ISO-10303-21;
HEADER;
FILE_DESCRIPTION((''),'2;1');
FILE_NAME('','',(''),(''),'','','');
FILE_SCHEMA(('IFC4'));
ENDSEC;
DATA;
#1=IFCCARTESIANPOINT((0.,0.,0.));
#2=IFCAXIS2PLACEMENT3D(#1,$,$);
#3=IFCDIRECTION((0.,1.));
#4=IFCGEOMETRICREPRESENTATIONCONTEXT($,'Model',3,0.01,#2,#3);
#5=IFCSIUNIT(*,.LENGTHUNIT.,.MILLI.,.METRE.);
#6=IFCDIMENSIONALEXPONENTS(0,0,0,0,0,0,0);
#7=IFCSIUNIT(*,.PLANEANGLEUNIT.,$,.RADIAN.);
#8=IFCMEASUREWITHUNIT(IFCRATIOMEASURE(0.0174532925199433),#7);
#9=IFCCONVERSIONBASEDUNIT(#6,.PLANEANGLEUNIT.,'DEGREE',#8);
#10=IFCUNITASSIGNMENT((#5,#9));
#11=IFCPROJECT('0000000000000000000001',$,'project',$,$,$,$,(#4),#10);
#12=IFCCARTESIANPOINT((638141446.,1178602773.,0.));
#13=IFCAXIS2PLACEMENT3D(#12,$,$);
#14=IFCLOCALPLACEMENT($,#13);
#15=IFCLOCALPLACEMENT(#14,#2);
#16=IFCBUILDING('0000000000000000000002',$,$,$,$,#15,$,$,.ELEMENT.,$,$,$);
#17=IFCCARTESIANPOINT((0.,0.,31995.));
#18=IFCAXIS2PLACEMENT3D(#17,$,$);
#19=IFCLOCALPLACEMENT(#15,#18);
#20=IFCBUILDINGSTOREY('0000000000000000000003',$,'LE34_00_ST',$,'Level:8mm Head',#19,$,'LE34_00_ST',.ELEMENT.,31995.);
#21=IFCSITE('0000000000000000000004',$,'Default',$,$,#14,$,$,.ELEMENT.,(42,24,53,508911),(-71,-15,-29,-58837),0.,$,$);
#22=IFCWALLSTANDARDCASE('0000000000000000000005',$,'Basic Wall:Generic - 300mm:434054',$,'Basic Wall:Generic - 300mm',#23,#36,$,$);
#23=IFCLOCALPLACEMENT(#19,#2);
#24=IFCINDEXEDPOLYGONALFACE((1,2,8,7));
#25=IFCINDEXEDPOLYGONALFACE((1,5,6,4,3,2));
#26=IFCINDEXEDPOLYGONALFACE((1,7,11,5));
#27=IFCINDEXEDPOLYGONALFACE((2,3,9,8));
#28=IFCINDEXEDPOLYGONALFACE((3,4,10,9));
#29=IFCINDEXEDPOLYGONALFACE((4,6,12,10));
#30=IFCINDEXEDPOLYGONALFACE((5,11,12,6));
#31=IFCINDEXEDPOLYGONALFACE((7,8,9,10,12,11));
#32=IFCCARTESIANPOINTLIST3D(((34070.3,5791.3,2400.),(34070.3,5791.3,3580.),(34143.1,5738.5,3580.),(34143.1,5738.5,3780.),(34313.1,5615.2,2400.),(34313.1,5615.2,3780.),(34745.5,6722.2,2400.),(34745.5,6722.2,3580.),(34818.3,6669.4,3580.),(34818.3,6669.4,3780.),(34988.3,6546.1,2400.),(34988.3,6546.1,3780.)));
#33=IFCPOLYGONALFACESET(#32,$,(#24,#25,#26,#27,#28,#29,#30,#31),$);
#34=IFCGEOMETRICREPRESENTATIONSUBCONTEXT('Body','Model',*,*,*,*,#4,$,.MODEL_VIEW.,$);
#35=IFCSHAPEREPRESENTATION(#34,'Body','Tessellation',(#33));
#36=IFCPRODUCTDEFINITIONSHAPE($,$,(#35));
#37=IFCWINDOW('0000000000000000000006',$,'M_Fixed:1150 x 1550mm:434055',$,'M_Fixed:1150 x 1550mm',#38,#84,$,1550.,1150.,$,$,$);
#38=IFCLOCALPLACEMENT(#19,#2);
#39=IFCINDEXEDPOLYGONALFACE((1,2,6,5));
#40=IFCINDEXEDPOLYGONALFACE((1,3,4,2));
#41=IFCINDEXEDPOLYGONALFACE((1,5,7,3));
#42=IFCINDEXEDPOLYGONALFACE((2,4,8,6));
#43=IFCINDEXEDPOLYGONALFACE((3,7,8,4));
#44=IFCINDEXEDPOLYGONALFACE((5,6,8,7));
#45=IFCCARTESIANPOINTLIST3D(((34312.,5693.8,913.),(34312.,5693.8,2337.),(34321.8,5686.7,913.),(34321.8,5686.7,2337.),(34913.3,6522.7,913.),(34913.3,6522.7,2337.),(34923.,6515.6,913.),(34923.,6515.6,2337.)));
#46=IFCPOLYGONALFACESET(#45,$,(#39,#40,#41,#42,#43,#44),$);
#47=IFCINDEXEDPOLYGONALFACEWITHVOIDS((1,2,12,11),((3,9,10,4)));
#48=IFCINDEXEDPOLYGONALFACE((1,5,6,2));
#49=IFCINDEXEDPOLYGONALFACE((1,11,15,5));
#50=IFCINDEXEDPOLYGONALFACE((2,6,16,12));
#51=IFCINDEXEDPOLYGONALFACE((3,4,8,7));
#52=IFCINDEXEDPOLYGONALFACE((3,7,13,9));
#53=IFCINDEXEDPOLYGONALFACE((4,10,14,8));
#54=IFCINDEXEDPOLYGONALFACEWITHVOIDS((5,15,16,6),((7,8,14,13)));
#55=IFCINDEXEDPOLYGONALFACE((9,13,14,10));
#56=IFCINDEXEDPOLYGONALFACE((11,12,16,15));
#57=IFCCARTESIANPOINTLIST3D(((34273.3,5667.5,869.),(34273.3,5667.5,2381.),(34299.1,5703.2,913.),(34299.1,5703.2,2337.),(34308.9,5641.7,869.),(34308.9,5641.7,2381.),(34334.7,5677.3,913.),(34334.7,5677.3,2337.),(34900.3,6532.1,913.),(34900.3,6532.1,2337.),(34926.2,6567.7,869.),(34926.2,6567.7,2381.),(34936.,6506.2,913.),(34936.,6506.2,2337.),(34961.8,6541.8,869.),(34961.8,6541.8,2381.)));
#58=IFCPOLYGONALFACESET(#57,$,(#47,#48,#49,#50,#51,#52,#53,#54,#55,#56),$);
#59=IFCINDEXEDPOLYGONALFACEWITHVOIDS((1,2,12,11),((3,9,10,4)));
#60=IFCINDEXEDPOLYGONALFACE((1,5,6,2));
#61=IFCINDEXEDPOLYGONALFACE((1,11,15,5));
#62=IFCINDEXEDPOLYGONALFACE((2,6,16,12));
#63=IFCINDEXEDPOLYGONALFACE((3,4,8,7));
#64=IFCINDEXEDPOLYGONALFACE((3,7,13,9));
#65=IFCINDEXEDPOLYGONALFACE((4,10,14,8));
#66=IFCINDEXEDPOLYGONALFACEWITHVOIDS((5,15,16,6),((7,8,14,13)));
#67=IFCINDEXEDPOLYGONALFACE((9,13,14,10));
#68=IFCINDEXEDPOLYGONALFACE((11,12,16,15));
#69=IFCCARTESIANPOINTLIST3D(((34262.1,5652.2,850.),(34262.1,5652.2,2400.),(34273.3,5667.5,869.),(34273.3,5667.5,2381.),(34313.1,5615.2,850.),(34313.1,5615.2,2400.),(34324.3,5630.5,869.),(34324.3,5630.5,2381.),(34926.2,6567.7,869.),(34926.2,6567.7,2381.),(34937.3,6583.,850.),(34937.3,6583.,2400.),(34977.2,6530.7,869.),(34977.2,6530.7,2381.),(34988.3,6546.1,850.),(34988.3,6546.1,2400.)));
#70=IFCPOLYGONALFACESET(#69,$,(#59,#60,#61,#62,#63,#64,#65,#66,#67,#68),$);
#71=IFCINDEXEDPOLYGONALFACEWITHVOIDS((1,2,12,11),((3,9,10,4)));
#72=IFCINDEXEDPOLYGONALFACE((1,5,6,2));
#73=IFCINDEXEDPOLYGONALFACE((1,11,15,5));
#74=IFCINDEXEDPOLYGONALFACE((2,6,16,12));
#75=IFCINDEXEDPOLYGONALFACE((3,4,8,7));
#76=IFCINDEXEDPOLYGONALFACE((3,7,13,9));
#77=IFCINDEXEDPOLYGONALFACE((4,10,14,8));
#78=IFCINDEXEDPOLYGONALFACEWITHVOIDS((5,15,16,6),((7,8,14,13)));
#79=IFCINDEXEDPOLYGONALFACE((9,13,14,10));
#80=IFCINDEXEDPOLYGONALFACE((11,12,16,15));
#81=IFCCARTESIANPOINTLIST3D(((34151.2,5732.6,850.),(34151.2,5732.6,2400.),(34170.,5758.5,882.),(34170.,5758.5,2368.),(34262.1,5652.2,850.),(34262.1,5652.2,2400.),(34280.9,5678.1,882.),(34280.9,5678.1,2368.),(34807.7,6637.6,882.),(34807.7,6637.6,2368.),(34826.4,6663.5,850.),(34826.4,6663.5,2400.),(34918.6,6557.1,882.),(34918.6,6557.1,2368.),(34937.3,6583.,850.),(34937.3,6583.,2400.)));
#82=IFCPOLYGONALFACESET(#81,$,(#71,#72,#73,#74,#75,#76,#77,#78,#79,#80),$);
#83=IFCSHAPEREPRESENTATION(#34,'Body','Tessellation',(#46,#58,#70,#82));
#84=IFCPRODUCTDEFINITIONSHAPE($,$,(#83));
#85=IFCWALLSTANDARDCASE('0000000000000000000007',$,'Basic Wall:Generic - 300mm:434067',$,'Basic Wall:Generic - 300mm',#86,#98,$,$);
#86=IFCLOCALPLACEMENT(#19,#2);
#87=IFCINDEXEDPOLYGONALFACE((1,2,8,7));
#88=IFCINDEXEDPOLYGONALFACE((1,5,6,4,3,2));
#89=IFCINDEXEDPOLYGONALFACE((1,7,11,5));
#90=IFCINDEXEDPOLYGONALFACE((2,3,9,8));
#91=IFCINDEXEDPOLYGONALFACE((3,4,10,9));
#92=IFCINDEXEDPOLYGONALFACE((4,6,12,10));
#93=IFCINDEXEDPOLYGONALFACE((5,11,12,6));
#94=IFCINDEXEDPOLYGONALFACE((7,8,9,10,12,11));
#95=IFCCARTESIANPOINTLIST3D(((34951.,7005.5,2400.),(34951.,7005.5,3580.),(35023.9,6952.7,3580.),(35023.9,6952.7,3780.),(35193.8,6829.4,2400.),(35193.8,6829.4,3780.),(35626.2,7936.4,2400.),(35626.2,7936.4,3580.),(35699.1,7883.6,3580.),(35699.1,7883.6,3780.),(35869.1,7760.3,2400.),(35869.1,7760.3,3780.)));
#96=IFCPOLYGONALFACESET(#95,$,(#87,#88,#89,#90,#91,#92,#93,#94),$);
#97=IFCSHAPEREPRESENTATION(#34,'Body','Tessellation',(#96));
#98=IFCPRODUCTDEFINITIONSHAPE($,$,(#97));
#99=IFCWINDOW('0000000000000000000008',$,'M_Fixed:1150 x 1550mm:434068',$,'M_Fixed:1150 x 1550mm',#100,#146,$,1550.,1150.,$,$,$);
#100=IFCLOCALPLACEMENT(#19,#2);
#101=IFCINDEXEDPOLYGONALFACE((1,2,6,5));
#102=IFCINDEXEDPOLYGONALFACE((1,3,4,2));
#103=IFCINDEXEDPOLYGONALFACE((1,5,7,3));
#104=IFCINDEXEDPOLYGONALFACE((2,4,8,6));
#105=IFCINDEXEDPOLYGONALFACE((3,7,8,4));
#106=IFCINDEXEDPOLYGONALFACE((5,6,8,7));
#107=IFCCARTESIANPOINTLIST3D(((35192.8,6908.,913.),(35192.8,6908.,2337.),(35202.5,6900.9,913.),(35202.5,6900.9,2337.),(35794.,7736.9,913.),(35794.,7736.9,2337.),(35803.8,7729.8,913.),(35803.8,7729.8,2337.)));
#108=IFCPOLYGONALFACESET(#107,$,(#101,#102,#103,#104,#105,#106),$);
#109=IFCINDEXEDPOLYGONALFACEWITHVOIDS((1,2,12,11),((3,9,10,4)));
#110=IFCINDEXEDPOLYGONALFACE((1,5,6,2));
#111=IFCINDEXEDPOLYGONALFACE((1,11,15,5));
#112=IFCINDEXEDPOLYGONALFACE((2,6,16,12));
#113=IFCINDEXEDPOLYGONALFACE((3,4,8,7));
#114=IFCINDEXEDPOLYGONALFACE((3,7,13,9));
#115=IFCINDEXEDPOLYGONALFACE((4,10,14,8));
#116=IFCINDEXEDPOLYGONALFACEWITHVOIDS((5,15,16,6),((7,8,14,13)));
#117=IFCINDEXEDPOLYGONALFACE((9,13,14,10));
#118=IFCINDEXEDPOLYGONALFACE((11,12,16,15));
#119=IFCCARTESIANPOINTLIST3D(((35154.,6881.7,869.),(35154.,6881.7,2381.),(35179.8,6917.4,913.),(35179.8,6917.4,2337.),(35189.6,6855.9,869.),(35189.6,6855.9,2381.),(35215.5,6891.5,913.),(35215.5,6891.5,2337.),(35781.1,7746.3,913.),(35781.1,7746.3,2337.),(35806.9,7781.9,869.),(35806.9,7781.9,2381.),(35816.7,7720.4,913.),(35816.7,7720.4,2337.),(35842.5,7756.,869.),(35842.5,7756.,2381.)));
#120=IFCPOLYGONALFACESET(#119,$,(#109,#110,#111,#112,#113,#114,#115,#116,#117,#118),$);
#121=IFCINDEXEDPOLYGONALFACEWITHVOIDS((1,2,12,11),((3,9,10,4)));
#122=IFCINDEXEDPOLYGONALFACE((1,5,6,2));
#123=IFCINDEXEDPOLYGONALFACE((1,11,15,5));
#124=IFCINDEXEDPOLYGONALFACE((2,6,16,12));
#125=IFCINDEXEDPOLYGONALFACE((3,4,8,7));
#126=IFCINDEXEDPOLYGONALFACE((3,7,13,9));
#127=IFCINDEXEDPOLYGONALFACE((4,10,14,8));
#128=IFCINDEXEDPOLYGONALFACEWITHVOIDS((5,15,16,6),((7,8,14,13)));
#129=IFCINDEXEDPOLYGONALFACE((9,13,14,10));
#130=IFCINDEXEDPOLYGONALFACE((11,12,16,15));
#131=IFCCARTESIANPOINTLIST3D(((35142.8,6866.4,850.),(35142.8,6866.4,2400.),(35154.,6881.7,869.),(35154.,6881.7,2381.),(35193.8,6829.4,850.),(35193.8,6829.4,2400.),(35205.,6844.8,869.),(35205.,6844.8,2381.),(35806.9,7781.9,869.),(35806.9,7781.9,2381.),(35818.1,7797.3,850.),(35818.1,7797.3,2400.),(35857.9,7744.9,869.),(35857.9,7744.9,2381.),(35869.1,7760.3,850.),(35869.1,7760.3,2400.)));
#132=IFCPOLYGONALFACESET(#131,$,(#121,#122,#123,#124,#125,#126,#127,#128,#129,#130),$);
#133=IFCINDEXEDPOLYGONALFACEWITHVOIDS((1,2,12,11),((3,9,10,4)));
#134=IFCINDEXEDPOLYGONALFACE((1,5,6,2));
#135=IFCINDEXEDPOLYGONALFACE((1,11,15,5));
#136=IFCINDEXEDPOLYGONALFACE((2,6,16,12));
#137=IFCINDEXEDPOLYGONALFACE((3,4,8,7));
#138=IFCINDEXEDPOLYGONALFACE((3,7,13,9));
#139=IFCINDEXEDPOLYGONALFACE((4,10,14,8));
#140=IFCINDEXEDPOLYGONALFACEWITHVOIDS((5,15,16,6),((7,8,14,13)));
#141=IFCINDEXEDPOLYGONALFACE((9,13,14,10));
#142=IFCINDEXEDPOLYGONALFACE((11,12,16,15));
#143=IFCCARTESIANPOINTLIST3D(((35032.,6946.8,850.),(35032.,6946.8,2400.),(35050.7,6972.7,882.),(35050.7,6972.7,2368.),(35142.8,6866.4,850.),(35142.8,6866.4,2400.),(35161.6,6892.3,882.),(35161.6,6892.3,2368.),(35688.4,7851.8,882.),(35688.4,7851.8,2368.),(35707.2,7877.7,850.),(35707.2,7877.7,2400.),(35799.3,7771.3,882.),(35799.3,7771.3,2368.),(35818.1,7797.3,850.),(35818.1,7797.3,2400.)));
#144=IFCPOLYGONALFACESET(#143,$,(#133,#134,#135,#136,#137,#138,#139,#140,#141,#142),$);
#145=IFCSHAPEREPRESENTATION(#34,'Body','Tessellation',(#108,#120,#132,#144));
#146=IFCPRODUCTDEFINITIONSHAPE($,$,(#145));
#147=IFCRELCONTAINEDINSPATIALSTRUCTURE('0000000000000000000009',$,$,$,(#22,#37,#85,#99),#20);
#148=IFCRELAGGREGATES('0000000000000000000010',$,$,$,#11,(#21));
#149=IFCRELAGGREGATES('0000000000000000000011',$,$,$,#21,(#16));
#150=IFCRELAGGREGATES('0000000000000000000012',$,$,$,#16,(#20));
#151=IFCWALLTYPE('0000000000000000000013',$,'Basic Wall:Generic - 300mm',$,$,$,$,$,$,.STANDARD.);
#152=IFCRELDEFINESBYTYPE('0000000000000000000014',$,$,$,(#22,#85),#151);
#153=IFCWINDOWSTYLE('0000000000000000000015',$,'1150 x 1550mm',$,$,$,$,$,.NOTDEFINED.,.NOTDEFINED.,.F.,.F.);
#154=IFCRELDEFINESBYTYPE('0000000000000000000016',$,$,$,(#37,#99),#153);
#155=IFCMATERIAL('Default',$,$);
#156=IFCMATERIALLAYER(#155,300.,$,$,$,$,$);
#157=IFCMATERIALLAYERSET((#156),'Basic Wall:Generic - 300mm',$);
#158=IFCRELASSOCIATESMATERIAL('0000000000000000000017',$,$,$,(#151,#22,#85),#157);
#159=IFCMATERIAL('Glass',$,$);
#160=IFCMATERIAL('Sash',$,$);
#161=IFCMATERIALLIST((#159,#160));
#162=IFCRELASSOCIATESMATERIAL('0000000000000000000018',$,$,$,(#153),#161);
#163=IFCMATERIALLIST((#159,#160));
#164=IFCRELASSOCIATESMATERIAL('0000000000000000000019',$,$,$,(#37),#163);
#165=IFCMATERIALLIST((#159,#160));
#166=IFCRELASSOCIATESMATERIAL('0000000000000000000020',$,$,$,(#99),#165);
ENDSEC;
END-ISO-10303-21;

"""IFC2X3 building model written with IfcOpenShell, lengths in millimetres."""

from ifc_helpers import new_model, entity, si_unit, converted_unit, direction, frame, frame_2d, origin, place, context, subcontext, project, spatial, polyline, rectangle, outline, extrude, clip, bounded_halfspace, source, transform, mapped, material, material_list, layer, layer_set, layer_usage, type_object, type_shapes, element, fill, save


model = new_model("IFC2X3")

# Units and contexts
model_context = context("Model", 3, precision=0.01, world=origin(), true_north=direction((0.0, 1.0)))
body_context = subcontext(model_context, "Body", "Model", "MODEL_VIEW")
ifc_project = project(units=[si_unit("LENGTHUNIT", "METRE", prefix="MILLI"), converted_unit("PLANEANGLEUNIT", "DEGREE", entity("IfcRatioMeasure", 0.0174532925199433), si_unit("PLANEANGLEUNIT", "RADIAN"), dimensions=[0, 0, 0, 0, 0, 0, 0])], contexts=[model_context])

# Site, building, storey
site_placement = place(None, frame((638141446.0, 1178602773.0, 0.0)))
site = spatial("IfcSite", under=ifc_project, at=site_placement, Name="Default", CompositionType="ELEMENT", RefLatitude=(42, 24, 53, 508911), RefLongitude=(-71, -15, -29, -58837), RefElevation=0.0)
building_placement = place(site_placement, origin())
building = spatial("IfcBuilding", under=site, at=building_placement, CompositionType="ELEMENT")
storey_placement = place(building_placement, frame((0.0, 0.0, 31995.0)))
storey = spatial("IfcBuildingStorey", under=building, at=storey_placement, Name="LE34_00_ST", ObjectType="Level:8mm Head", LongName="LE34_00_ST", CompositionType="ELEMENT", Elevation=31995.0)

# Walls, openings, windows
ifc_material_1 = material(Name="Default")
ifc_layer_1 = layer(ifc_material_1, 300.0)
ifc_layer_set_1 = layer_set([ifc_layer_1], Name="Basic Wall:Generic - 300mm")
wall_type_1 = type_object("IfcWallType", Name="Basic Wall:Generic - 300mm", PredefinedType="STANDARD", material=ifc_layer_set_1)
ifc_material_2 = material(Name="Glass")
ifc_material_3 = material(Name="Sash")
ifc_material_list_1 = material_list([ifc_material_2, ifc_material_3])
window_style_1 = type_object("IfcWindowStyle", Name="1150 x 1550mm", ConstructionType="NOTDEFINED", OperationType="NOTDEFINED", ParameterTakesPrecedence=False, Sizeable=False, material=ifc_material_list_1)
shared_shape_1 = source(origin(), body_context, "Body", "SweptSolid", [
    extrude(rectangle(XDim=1024.0, YDim=12.0, at=frame_2d((0.0, 0.0), x_axis=(1.0, 0.0))), frame((575.0, 285.0, 63.0), z_axis=(0.0, 0.0, 1.0), x_axis=(-1.0, 0.0, 0.0)), (0.0, 0.0, 1.0), 1424.0),
    extrude(outline(polyline([(-556.0, -756.0), (556.0, -756.0), (556.0, 756.0), (-556.0, 756.0), (-556.0, -756.0)]), holes=[polyline([(-512.0, -712.0), (-512.0, 712.0), (512.0, 712.0), (512.0, -712.0), (-512.0, -712.0)])]), frame((575.0, 307.0, 775.0), z_axis=(0.0, -1.0, 0.0), x_axis=(-1.0, 0.0, 0.0)), (0.0, 0.0, 1.0), 44.0),
    extrude(outline(polyline([(-575.0, -775.0), (575.0, -775.0), (575.0, 775.0), (-575.0, 775.0), (-575.0, -775.0)]), holes=[polyline([(-556.0, -756.0), (-556.0, 756.0), (556.0, 756.0), (556.0, -756.0), (-556.0, -756.0)])]), frame((575.0, 326.0, 775.0), z_axis=(0.0, -1.0, 0.0), x_axis=(-1.0, 0.0, 0.0)), (0.0, 0.0, 1.0), 63.0),
    extrude(outline(polyline([(-575.0, -775.0), (575.0, -775.0), (575.0, 775.0), (-575.0, 775.0), (-575.0, -775.0)]), holes=[polyline([(-543.0, -743.0), (-543.0, 743.0), (543.0, 743.0), (543.0, -743.0), (-543.0, -743.0)])]), frame((575.0, 263.0, 775.0), z_axis=(0.0, -1.0, 0.0), x_axis=(-1.0, 0.0, 0.0)), (0.0, 0.0, 1.0), 137.0),
])
type_shapes(window_style_1, [shared_shape_1])
ifc_layer_usage_1 = layer_usage(ifc_layer_set_1, "AXIS2", "POSITIVE", -150.0)
wall_1_placement = place(storey_placement, frame((34191.7, 5703.2, 2400.0), z_axis=(0.0, 0.0, 1.0), x_axis=(0.587164, 0.809468, 0.0)))
wall_1 = element("IfcWallStandardCase", 1, at=wall_1_placement, inside=storey, type_object=wall_type_1, material=ifc_layer_usage_1, Name="Basic Wall:Generic - 300mm:434054", ObjectType="Basic Wall:Generic - 300mm", context=body_context, shape_type="Clipping", body=[
    clip(clip(extrude(rectangle(XDim=1150.0, YDim=300.0, at=frame_2d((575.0, 0.0), x_axis=(-1.0, 0.0))), origin(), (0.0, 0.0, 1.0), 1380.0), bounded_halfspace(frame((0.0, 60.0, 1180.0), z_axis=(0.0, 0.0, -1.0), x_axis=(0.0, 1.0, 0.0)), True, frame((0.0, 60.0, 1180.0), z_axis=(0.0, 0.0, -1.0), x_axis=(0.0, 1.0, 0.0)), polyline([(0.0, 0.0), (90.0, 0.0), (90.0, 1150.0), (0.0, 1150.0), (0.0, 0.0)]))), bounded_halfspace(frame((1150.0, 60.0, 1180.0), z_axis=(0.0, -1.0, 0.0), x_axis=(0.0, 0.0, 1.0)), True, frame((1150.0, 60.0, 1180.0), z_axis=(0.0, -1.0, 0.0), x_axis=(0.0, 0.0, 1.0)), polyline([(0.0, 0.0), (200.0, 0.0), (200.0, 1150.0), (0.0, 1150.0), (0.0, 0.0)]))),
])
opening_1_placement = place(wall_1_placement, frame((1150.0, 150.0, -1550.0)))
opening_1 = element("IfcOpeningElement", 2, at=opening_1_placement, cuts=wall_1, ObjectType="Opening", context=body_context, shape_type="SweptSolid", body=[
    extrude(rectangle(XDim=1550.0, YDim=1150.0, at=frame_2d((775.0, 575.0), x_axis=(1.0, 0.0))), frame((0.0, 0.0, 0.0), z_axis=(0.0, -1.0, 0.0), x_axis=(0.0, 0.0, 1.0)), (0.0, 0.0, 1.0), 300.0),
])
ifc_material_list_2 = material_list([ifc_material_2, ifc_material_3])
window_1_placement = place(opening_1_placement, frame((0.0, 26.0, 0.0), z_axis=(0.0, 0.0, 1.0), x_axis=(-1.0, 0.0, 0.0)))
window_1 = element("IfcWindow", 3, at=window_1_placement, inside=storey, type_object=window_style_1, material=ifc_material_list_2, Name="M_Fixed:1150 x 1550mm:434055", ObjectType="M_Fixed:1150 x 1550mm", OverallHeight=1550.0, OverallWidth=1150.0, context=body_context, shape_type="MappedRepresentation", body=[
    mapped(shared_shape_1, transform((0.0, 0.0, 0.0), scale=1.0)),
])
fill(opening_1, window_1)
ifc_layer_usage_2 = layer_usage(ifc_layer_set_1, "AXIS2", "POSITIVE", -150.0)
wall_2_placement = place(storey_placement, frame((35072.4, 6917.4, 2400.0), z_axis=(0.0, 0.0, 1.0), x_axis=(0.587164, 0.809468, 0.0)))
wall_2 = element("IfcWallStandardCase", 4, at=wall_2_placement, inside=storey, type_object=wall_type_1, material=ifc_layer_usage_2, Name="Basic Wall:Generic - 300mm:434067", ObjectType="Basic Wall:Generic - 300mm", context=body_context, shape_type="Clipping", body=[
    clip(clip(extrude(rectangle(XDim=1150.0, YDim=300.0, at=frame_2d((575.0, 0.0), x_axis=(-1.0, 0.0))), origin(), (0.0, 0.0, 1.0), 1380.0), bounded_halfspace(frame((0.0, 60.0, 1180.0), z_axis=(0.0, 0.0, -1.0), x_axis=(0.0, 1.0, 0.0)), True, frame((0.0, 60.0, 1180.0), z_axis=(0.0, 0.0, -1.0), x_axis=(0.0, 1.0, 0.0)), polyline([(0.0, 0.0), (90.0, 0.0), (90.0, 1150.0), (0.0, 1150.0), (0.0, 0.0)]))), bounded_halfspace(frame((1150.0, 60.0, 1180.0), z_axis=(0.0, -1.0, 0.0), x_axis=(0.0, 0.0, 1.0)), True, frame((1150.0, 60.0, 1180.0), z_axis=(0.0, -1.0, 0.0), x_axis=(0.0, 0.0, 1.0)), polyline([(0.0, 0.0), (200.0, 0.0), (200.0, 1150.0), (0.0, 1150.0), (0.0, 0.0)]))),
])
opening_2_placement = place(wall_2_placement, frame((1150.0, 150.0, -1550.0)))
opening_2 = element("IfcOpeningElement", 5, at=opening_2_placement, cuts=wall_2, ObjectType="Opening", context=body_context, shape_type="SweptSolid", body=[
    extrude(rectangle(XDim=1550.0, YDim=1150.0, at=frame_2d((775.0, 575.0), x_axis=(1.0, 0.0))), frame((0.0, 0.0, 0.0), z_axis=(0.0, -1.0, 0.0), x_axis=(0.0, 0.0, 1.0)), (0.0, 0.0, 1.0), 300.0),
])
ifc_material_list_3 = material_list([ifc_material_2, ifc_material_3])
window_2_placement = place(opening_2_placement, frame((0.0, 26.0, 0.0), z_axis=(0.0, 0.0, 1.0), x_axis=(-1.0, 0.0, 0.0)))
window_2 = element("IfcWindow", 6, at=window_2_placement, inside=storey, type_object=window_style_1, material=ifc_material_list_3, Name="M_Fixed:1150 x 1550mm:434068", ObjectType="M_Fixed:1150 x 1550mm", OverallHeight=1550.0, OverallWidth=1150.0, context=body_context, shape_type="MappedRepresentation", body=[
    mapped(shared_shape_1, transform((0.0, 0.0, 0.0), scale=1.0)),
])
fill(opening_2, window_2)

save(model, "model.ifc")
